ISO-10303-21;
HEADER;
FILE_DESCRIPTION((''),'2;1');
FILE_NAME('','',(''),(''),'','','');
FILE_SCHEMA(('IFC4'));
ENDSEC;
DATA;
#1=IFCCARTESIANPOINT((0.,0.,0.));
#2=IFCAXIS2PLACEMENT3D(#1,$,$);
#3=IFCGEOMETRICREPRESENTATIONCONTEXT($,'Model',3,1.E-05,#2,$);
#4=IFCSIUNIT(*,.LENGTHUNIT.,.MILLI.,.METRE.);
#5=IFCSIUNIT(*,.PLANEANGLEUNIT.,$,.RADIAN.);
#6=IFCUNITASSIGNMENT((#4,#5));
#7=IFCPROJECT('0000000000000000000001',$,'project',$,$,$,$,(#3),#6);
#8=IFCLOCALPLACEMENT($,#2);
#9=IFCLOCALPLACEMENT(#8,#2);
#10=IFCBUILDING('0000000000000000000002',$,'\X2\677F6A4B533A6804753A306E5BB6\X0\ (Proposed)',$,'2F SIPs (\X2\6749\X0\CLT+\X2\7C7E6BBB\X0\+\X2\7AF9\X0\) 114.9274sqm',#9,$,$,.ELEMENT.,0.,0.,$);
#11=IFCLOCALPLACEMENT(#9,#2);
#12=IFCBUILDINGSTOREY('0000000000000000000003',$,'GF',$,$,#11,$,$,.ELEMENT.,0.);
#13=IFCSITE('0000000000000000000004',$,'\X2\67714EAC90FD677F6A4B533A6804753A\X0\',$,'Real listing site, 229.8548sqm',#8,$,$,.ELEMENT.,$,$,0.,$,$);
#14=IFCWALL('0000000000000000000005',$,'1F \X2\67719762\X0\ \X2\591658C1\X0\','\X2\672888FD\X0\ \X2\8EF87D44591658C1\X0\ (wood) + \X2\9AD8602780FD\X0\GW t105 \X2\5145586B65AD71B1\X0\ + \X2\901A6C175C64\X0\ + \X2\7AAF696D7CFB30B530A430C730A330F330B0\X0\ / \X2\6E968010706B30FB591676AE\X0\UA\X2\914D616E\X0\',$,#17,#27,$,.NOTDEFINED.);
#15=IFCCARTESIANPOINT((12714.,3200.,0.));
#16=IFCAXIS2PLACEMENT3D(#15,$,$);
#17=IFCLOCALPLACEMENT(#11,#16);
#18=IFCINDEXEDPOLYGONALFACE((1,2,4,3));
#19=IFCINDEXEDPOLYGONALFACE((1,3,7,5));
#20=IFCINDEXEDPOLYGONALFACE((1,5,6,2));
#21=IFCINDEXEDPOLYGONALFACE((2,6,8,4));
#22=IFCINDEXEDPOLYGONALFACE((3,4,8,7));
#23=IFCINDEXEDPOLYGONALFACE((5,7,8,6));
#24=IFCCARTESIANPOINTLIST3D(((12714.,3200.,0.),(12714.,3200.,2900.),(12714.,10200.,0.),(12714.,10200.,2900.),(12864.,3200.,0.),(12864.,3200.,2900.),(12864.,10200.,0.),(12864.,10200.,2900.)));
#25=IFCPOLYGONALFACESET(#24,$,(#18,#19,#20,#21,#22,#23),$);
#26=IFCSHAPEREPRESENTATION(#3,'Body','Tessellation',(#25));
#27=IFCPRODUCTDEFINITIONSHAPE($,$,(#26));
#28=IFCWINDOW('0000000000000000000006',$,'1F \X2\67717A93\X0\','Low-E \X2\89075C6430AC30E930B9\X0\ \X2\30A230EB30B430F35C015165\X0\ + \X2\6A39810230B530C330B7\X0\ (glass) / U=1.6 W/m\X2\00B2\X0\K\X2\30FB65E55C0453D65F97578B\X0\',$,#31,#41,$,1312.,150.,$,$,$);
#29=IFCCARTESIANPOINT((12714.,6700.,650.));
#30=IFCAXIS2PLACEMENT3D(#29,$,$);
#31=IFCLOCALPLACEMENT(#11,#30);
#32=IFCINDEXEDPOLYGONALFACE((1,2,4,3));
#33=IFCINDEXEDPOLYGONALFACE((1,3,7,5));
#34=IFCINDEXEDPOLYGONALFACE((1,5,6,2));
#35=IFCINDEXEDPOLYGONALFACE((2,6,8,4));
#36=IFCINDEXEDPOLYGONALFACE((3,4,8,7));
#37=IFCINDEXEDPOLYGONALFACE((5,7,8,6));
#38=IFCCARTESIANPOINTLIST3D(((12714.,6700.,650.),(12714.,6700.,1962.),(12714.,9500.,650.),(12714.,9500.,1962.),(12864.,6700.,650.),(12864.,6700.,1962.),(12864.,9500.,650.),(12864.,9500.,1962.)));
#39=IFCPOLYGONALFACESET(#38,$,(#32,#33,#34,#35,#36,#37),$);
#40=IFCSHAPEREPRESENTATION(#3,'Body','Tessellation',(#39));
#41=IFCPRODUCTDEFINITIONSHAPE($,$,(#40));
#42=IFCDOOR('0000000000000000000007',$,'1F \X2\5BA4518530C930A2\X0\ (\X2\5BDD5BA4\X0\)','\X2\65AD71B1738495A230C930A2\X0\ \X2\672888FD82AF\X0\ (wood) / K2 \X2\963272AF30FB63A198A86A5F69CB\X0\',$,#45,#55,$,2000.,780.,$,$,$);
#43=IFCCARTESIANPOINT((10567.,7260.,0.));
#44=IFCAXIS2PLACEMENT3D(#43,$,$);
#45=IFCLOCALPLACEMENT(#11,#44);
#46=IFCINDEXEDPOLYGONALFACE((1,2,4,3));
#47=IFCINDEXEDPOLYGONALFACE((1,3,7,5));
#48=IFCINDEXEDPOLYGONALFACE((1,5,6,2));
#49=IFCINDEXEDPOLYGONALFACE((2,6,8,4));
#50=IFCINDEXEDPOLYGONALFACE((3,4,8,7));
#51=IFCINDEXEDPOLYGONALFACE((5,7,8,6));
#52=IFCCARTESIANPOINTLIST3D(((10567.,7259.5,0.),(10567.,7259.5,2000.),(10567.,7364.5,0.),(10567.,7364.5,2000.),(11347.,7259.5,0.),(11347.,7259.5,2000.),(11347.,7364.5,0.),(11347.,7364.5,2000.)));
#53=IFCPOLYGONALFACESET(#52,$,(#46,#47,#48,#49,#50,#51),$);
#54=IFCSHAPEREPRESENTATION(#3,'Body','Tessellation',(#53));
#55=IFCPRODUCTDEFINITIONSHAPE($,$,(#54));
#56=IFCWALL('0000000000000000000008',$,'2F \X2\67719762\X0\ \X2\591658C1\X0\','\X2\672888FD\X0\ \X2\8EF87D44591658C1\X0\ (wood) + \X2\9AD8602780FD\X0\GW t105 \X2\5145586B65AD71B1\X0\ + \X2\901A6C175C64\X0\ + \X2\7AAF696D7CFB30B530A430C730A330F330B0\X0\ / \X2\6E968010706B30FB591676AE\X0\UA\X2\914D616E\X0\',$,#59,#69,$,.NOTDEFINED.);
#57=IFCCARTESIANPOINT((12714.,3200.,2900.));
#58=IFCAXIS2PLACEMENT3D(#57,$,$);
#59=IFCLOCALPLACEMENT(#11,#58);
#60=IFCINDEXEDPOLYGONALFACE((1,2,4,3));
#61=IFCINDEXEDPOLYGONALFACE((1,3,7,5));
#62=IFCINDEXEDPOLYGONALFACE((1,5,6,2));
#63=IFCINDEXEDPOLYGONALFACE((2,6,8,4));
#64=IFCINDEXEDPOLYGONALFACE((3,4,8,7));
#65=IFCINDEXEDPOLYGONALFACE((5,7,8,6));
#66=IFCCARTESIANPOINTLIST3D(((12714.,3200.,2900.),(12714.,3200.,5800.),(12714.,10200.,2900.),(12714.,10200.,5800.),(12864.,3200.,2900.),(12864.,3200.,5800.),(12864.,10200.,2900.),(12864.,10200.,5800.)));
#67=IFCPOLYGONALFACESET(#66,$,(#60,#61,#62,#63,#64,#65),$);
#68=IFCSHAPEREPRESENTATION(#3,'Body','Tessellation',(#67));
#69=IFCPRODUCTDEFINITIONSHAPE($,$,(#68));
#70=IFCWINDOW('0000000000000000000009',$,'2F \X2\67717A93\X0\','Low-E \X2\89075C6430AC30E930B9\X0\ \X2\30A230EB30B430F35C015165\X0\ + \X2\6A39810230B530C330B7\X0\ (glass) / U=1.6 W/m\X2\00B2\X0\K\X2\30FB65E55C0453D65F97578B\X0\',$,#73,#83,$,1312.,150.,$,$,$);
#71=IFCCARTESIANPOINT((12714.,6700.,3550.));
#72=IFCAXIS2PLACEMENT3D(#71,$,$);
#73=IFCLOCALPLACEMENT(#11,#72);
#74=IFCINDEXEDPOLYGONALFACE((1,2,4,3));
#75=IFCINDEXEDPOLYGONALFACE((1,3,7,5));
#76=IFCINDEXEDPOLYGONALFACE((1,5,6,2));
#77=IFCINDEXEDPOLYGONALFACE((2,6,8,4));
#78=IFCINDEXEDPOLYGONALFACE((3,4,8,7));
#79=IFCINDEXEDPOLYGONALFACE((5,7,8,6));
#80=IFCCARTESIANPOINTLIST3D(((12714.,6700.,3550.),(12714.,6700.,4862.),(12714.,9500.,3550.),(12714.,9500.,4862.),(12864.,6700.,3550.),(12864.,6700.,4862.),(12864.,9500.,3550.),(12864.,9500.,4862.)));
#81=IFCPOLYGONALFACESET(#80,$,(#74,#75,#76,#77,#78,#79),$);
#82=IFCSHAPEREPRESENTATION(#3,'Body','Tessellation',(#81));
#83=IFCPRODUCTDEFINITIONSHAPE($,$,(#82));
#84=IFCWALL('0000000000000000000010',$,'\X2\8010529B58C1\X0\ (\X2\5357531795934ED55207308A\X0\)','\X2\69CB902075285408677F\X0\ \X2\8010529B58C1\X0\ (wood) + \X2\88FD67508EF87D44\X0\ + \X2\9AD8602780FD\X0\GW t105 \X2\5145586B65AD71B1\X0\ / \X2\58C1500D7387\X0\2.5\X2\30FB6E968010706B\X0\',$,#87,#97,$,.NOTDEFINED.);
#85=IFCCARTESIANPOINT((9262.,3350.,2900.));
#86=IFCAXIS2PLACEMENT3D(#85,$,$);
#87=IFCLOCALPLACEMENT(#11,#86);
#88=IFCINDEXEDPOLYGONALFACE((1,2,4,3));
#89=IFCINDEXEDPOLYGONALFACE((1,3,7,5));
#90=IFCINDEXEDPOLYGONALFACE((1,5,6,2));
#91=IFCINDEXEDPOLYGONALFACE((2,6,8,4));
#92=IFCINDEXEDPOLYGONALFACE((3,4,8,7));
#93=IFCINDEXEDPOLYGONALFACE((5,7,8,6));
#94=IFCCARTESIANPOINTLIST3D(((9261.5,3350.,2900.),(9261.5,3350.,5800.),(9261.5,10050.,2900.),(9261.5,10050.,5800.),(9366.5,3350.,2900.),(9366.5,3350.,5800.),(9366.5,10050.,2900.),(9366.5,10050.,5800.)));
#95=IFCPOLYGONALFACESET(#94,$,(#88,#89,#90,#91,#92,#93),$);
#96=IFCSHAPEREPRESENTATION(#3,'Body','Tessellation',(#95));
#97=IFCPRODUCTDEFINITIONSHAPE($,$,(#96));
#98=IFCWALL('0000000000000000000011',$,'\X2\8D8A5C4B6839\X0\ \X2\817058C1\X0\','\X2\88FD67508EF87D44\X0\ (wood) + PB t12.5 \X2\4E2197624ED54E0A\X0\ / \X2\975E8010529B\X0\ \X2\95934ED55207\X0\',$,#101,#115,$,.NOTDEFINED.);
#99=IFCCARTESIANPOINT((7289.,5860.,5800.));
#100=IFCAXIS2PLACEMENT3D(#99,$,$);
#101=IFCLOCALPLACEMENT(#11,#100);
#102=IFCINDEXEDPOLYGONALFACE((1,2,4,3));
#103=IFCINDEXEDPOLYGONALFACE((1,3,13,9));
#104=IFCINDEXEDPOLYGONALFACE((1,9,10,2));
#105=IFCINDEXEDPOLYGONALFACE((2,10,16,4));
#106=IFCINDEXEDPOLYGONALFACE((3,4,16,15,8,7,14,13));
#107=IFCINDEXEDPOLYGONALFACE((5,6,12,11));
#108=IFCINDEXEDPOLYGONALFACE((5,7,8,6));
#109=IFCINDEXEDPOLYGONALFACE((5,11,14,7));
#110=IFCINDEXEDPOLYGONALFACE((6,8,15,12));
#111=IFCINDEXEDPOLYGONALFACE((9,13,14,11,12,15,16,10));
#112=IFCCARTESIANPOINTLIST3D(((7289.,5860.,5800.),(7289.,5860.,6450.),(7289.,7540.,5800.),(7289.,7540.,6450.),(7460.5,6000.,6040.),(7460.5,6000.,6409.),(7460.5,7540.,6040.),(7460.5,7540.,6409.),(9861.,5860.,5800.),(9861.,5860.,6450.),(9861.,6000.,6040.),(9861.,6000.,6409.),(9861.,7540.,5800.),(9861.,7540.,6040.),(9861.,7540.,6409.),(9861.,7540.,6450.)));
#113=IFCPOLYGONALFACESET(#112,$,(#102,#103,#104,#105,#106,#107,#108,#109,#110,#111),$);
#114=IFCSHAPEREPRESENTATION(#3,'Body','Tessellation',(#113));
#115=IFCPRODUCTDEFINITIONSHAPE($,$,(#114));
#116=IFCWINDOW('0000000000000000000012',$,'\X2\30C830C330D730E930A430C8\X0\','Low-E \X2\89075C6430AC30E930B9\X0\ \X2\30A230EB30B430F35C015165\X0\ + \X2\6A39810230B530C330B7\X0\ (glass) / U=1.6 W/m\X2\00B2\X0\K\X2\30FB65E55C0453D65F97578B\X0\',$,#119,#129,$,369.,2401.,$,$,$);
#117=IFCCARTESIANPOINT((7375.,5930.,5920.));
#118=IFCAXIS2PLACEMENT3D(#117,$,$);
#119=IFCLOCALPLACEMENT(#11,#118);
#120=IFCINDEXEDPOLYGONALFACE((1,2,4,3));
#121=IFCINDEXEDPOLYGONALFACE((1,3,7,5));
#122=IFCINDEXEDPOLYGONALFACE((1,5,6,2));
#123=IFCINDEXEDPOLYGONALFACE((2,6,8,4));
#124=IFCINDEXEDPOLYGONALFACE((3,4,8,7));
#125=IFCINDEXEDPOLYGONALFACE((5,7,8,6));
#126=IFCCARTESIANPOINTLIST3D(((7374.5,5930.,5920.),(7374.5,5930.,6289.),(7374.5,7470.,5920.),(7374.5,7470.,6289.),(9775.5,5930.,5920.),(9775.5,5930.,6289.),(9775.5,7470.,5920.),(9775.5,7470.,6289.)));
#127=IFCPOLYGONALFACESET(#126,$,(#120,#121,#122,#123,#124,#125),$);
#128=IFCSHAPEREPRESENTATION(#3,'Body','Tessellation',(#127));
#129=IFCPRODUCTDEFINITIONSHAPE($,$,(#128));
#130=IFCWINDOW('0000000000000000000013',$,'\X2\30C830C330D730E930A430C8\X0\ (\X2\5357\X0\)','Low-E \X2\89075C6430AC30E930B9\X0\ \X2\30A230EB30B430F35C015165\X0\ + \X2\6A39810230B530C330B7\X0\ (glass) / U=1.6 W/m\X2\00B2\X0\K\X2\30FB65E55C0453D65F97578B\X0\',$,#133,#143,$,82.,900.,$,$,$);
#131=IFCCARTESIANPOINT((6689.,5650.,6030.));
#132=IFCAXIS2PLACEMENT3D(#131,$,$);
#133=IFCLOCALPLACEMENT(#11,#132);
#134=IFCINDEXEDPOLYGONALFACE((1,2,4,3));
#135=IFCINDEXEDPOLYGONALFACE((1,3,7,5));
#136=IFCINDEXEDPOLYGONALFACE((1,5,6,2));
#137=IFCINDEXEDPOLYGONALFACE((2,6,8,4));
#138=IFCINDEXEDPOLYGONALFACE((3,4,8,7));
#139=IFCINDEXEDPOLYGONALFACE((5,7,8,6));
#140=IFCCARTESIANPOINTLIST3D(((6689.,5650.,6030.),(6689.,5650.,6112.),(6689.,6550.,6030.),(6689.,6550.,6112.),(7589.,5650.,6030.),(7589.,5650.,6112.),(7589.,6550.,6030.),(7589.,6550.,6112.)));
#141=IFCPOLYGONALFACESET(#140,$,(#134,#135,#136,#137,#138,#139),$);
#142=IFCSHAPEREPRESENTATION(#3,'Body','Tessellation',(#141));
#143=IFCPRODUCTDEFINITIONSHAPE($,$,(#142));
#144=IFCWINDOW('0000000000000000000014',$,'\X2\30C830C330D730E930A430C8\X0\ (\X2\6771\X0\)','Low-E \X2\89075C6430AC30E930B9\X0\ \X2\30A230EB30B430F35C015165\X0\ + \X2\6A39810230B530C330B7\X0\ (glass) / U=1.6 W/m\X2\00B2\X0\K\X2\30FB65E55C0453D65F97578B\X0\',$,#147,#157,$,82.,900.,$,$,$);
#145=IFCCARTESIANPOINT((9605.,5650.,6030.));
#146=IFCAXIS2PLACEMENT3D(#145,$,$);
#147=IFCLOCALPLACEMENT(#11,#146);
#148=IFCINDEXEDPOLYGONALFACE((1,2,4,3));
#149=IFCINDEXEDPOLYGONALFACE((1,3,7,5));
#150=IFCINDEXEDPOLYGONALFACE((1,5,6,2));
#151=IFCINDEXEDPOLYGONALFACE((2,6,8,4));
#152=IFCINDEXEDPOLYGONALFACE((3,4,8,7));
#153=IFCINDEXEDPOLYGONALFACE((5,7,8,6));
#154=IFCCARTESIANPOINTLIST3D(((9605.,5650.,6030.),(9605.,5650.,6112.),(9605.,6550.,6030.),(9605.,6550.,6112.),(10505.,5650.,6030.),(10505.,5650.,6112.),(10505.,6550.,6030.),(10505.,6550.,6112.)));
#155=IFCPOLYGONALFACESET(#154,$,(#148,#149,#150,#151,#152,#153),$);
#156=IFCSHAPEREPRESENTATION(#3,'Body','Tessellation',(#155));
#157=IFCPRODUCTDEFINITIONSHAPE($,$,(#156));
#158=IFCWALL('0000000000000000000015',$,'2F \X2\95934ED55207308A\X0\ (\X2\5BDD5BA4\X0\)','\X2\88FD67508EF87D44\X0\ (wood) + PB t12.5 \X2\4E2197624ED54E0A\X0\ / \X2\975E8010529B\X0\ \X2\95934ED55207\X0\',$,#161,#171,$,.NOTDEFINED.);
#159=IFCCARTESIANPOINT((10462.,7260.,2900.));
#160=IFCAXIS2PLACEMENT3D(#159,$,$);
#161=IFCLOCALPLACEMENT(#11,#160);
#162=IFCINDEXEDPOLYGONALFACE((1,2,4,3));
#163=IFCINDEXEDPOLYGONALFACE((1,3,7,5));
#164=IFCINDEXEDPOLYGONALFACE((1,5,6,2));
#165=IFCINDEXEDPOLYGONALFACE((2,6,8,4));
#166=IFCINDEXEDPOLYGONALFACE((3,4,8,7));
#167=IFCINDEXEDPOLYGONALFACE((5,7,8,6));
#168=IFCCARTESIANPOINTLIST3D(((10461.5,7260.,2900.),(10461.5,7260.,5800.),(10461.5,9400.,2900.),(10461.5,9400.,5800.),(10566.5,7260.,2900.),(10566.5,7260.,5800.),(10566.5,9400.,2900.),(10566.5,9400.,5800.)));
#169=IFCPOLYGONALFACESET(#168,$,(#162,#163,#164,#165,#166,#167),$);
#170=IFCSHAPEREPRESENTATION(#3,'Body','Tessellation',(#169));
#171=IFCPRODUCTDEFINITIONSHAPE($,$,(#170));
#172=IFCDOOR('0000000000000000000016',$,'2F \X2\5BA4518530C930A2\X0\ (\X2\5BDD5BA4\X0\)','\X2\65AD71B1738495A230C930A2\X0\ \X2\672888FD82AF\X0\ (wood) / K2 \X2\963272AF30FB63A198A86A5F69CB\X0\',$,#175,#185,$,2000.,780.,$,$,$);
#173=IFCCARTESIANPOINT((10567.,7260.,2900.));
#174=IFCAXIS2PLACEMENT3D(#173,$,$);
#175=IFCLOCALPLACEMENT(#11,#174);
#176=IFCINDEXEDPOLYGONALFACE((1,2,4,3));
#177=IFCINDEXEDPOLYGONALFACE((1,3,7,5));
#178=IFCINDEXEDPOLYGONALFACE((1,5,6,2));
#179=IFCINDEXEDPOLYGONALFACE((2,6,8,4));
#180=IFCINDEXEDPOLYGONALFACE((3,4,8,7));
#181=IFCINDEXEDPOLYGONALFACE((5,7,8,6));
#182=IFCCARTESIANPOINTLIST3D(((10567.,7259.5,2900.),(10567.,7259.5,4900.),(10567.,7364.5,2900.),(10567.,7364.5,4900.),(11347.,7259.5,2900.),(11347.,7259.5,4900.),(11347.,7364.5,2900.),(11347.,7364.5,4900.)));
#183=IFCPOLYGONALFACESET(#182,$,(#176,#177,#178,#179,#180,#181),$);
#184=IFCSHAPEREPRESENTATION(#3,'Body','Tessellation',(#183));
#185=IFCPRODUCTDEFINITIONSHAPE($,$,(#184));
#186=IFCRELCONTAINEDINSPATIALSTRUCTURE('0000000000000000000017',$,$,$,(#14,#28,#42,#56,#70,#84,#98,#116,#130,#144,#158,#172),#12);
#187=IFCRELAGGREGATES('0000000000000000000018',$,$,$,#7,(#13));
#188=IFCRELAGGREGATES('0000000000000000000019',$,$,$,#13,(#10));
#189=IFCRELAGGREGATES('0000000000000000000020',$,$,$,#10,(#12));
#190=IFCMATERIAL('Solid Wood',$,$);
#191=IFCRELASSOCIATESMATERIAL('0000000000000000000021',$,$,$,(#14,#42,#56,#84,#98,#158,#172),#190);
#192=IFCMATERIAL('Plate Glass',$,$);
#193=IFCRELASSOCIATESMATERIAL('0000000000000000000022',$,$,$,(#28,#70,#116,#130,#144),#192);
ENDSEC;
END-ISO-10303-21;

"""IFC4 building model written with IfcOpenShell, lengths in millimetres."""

from ifc_helpers import new_model, si_unit, frame, frame_2d, origin, place, context, project, spatial, rectangle, extrude, material, element, fill, save


model = new_model("IFC4")

# Units and contexts
model_context = context("Model", 3, precision=1e-05, world=origin())
ifc_project = project(units=[si_unit("LENGTHUNIT", "METRE", prefix="MILLI"), si_unit("PLANEANGLEUNIT", "RADIAN")], contexts=[model_context])

# Site, building, storey
site_placement = place(None, origin())
site = spatial("IfcSite", under=ifc_project, at=site_placement, Name="東京都板橋区栄町", ObjectType="Real listing site, 229.8548sqm", CompositionType="ELEMENT", RefElevation=0.0)
building_placement = place(site_placement, origin())
building = spatial("IfcBuilding", under=site, at=building_placement, Name="板橋区栄町の家 (Proposed)", ObjectType="2F SIPs (杉CLT+籾殻+竹) 114.9274sqm", CompositionType="ELEMENT", ElevationOfRefHeight=0.0, ElevationOfTerrain=0.0)
storey_placement = place(building_placement, origin())
storey = spatial("IfcBuildingStorey", under=building, at=storey_placement, Name="GF", CompositionType="ELEMENT", Elevation=0.0)

# Wall, opening, window
ifc_material_1 = material(Name="Solid Wood")
wall_1_placement = place(storey_placement, frame((12714.0, 3200.0, 0.0)))
wall_1 = element("IfcWall", 1, at=wall_1_placement, inside=storey, material=ifc_material_1, Name="1F 東面 外壁", Description="木製 軸組外壁 (wood) + 高性能GW t105 充填断熱 + 通気層 + 窯業系サイディング / 準耐火・外皮UA配慮", PredefinedType="NOTDEFINED", context=model_context, shape_type="SweptSolid", body=[
    extrude(rectangle(XDim=150.0, YDim=7000.0, at=frame_2d((75.0, 3500.0))), frame((12714.0, 3200.0, 0.0)), (0.0, 0.0, 1.0), 2900.0),
])
opening_1_placement = place(storey_placement, frame((12714.0, 6700.0, 650.0)))
opening_1 = element("IfcOpeningElement", 2, at=opening_1_placement, cuts=wall_1, PredefinedType="NOTDEFINED", context=model_context, shape_type="SweptSolid", body=[
    extrude(rectangle(XDim=150.0, YDim=2800.0, at=frame_2d((75.0, 1400.0))), frame((12714.0, 6700.0, 650.0)), (0.0, 0.0, 1.0), 1312.0),
])
ifc_material_2 = material(Name="Plate Glass")
window_1_placement = place(storey_placement, frame((12714.0, 6700.0, 650.0)))
window_1 = element("IfcWindow", 3, at=window_1_placement, inside=storey, material=ifc_material_2, Name="1F 東窓", Description="Low-E 複層ガラス アルゴン封入 + 樹脂サッシ (glass) / U=1.6 W/m²K・日射取得型", OverallHeight=1312.0, OverallWidth=150.0, context=model_context, shape_type="SweptSolid", body=[
    extrude(rectangle(XDim=150.0, YDim=2800.0, at=frame_2d((75.0, 1400.0))), frame((12714.0, 6700.0, 650.0)), (0.0, 0.0, 1.0), 1312.0),
])
fill(opening_1, window_1)

# Door
door_1_placement = place(storey_placement, frame((10567.0, 7260.0, 0.0)))
element("IfcDoor", 4, at=door_1_placement, inside=storey, material=ifc_material_1, Name="1F 室内ドア (寝室)", Description="断熱玄関ドア 木製芯 (wood) / K2 防犯・採風機構", OverallHeight=2000.0, OverallWidth=780.0, context=model_context, shape_type="SweptSolid", body=[
    extrude(rectangle(XDim=780.0, YDim=105.0, at=frame_2d((390.0, 52.0))), frame((10567.0, 7260.0, 0.0)), (0.0, 0.0, 1.0), 2000.0),
])

# Wall, opening, window
wall_2_placement = place(storey_placement, frame((12714.0, 3200.0, 2900.0)))
wall_2 = element("IfcWall", 5, at=wall_2_placement, inside=storey, material=ifc_material_1, Name="2F 東面 外壁", Description="木製 軸組外壁 (wood) + 高性能GW t105 充填断熱 + 通気層 + 窯業系サイディング / 準耐火・外皮UA配慮", PredefinedType="NOTDEFINED", context=model_context, shape_type="SweptSolid", body=[
    extrude(rectangle(XDim=150.0, YDim=7000.0, at=frame_2d((75.0, 3500.0))), frame((12714.0, 3200.0, 2900.0)), (0.0, 0.0, 1.0), 2900.0),
])
opening_2_placement = place(storey_placement, frame((12714.0, 6700.0, 3550.0)))
opening_2 = element("IfcOpeningElement", 6, at=opening_2_placement, cuts=wall_2, PredefinedType="NOTDEFINED", context=model_context, shape_type="SweptSolid", body=[
    extrude(rectangle(XDim=150.0, YDim=2800.0, at=frame_2d((75.0, 1400.0))), frame((12714.0, 6700.0, 3550.0)), (0.0, 0.0, 1.0), 1312.0),
])
window_2_placement = place(storey_placement, frame((12714.0, 6700.0, 3550.0)))
window_2 = element("IfcWindow", 7, at=window_2_placement, inside=storey, material=ifc_material_2, Name="2F 東窓", Description="Low-E 複層ガラス アルゴン封入 + 樹脂サッシ (glass) / U=1.6 W/m²K・日射取得型", OverallHeight=1312.0, OverallWidth=150.0, context=model_context, shape_type="SweptSolid", body=[
    extrude(rectangle(XDim=150.0, YDim=2800.0, at=frame_2d((75.0, 1400.0))), frame((12714.0, 6700.0, 3550.0)), (0.0, 0.0, 1.0), 1312.0),
])
fill(opening_2, window_2)

# Wall
wall_3_placement = place(storey_placement, frame((9262.0, 3350.0, 2900.0)))
element("IfcWall", 8, at=wall_3_placement, inside=storey, material=ifc_material_1, Name="耐力壁 (南北間仕切り)", Description="構造用合板 耐力壁 (wood) + 製材軸組 + 高性能GW t105 充填断熱 / 壁倍率2.5・準耐火", PredefinedType="NOTDEFINED", context=model_context, shape_type="SweptSolid", body=[
    extrude(rectangle(XDim=105.0, YDim=6700.0, at=frame_2d((52.0, 3350.0))), frame((9262.0, 3350.0, 2900.0)), (0.0, 0.0, 1.0), 2900.0),
])

# Wall, openings, windows
wall_4_placement = place(storey_placement, frame((7289.0, 5860.0, 5800.0)))
wall_4 = element("IfcWall", 9, at=wall_4_placement, inside=storey, material=ifc_material_1, Name="越屋根 腰壁", Description="製材軸組 (wood) + PB t12.5 両面仕上 / 非耐力 間仕切", PredefinedType="NOTDEFINED", context=model_context, shape_type="SweptSolid", body=[
    extrude(rectangle(XDim=2572.0, YDim=1680.0, at=frame_2d((1286.0, 840.0))), frame((7289.0, 5860.0, 5800.0)), (0.0, 0.0, 1.0), 650.0),
])
opening_3_placement = place(storey_placement, frame((7375.0, 5930.0, 5920.0)))
opening_3 = element("IfcOpeningElement", 10, at=opening_3_placement, cuts=wall_4, PredefinedType="NOTDEFINED", context=model_context, shape_type="SweptSolid", body=[
    extrude(rectangle(XDim=2401.0, YDim=1540.0, at=frame_2d((1200.0, 770.0))), frame((7375.0, 5930.0, 5920.0)), (0.0, 0.0, 1.0), 369.0),
])
opening_4_placement = place(storey_placement, frame((6689.0, 5650.0, 6030.0)))
opening_4 = element("IfcOpeningElement", 11, at=opening_4_placement, cuts=wall_4, PredefinedType="NOTDEFINED", context=model_context, shape_type="SweptSolid", body=[
    extrude(rectangle(XDim=900.0, YDim=900.0, at=frame_2d((450.0, 450.0))), frame((6689.0, 5650.0, 6030.0)), (0.0, 0.0, 1.0), 82.0),
])
opening_5_placement = place(storey_placement, frame((9605.0, 5650.0, 6030.0)))
opening_5 = element("IfcOpeningElement", 12, at=opening_5_placement, cuts=wall_4, PredefinedType="NOTDEFINED", context=model_context, shape_type="SweptSolid", body=[
    extrude(rectangle(XDim=900.0, YDim=900.0, at=frame_2d((450.0, 450.0))), frame((9605.0, 5650.0, 6030.0)), (0.0, 0.0, 1.0), 82.0),
])
window_3_placement = place(storey_placement, frame((7375.0, 5930.0, 5920.0)))
window_3 = element("IfcWindow", 13, at=window_3_placement, inside=storey, material=ifc_material_2, Name="トップライト", Description="Low-E 複層ガラス アルゴン封入 + 樹脂サッシ (glass) / U=1.6 W/m²K・日射取得型", OverallHeight=369.0, OverallWidth=2401.0, context=model_context, shape_type="SweptSolid", body=[
    extrude(rectangle(XDim=2401.0, YDim=1540.0, at=frame_2d((1200.0, 770.0))), frame((7375.0, 5930.0, 5920.0)), (0.0, 0.0, 1.0), 369.0),
])
fill(opening_3, window_3)
window_4_placement = place(storey_placement, frame((6689.0, 5650.0, 6030.0)))
window_4 = element("IfcWindow", 14, at=window_4_placement, inside=storey, material=ifc_material_2, Name="トップライト (南)", Description="Low-E 複層ガラス アルゴン封入 + 樹脂サッシ (glass) / U=1.6 W/m²K・日射取得型", OverallHeight=82.0, OverallWidth=900.0, context=model_context, shape_type="SweptSolid", body=[
    extrude(rectangle(XDim=900.0, YDim=900.0, at=frame_2d((450.0, 450.0))), frame((6689.0, 5650.0, 6030.0)), (0.0, 0.0, 1.0), 82.0),
])
fill(opening_4, window_4)
window_5_placement = place(storey_placement, frame((9605.0, 5650.0, 6030.0)))
window_5 = element("IfcWindow", 15, at=window_5_placement, inside=storey, material=ifc_material_2, Name="トップライト (東)", Description="Low-E 複層ガラス アルゴン封入 + 樹脂サッシ (glass) / U=1.6 W/m²K・日射取得型", OverallHeight=82.0, OverallWidth=900.0, context=model_context, shape_type="SweptSolid", body=[
    extrude(rectangle(XDim=900.0, YDim=900.0, at=frame_2d((450.0, 450.0))), frame((9605.0, 5650.0, 6030.0)), (0.0, 0.0, 1.0), 82.0),
])
fill(opening_5, window_5)

# Wall
wall_5_placement = place(storey_placement, frame((10462.0, 7260.0, 2900.0)))
element("IfcWall", 16, at=wall_5_placement, inside=storey, material=ifc_material_1, Name="2F 間仕切り (寝室)", Description="製材軸組 (wood) + PB t12.5 両面仕上 / 非耐力 間仕切", PredefinedType="NOTDEFINED", context=model_context, shape_type="SweptSolid", body=[
    extrude(rectangle(XDim=105.0, YDim=2140.0, at=frame_2d((52.0, 1070.0))), frame((10462.0, 7260.0, 2900.0)), (0.0, 0.0, 1.0), 2900.0),
])

# Door
door_2_placement = place(storey_placement, frame((10567.0, 7260.0, 2900.0)))
element("IfcDoor", 17, at=door_2_placement, inside=storey, material=ifc_material_1, Name="2F 室内ドア (寝室)", Description="断熱玄関ドア 木製芯 (wood) / K2 防犯・採風機構", OverallHeight=2000.0, OverallWidth=780.0, context=model_context, shape_type="SweptSolid", body=[
    extrude(rectangle(XDim=780.0, YDim=105.0, at=frame_2d((390.0, 52.0))), frame((10567.0, 7260.0, 2900.0)), (0.0, 0.0, 1.0), 2000.0),
])

save(model, "model.ifc")
